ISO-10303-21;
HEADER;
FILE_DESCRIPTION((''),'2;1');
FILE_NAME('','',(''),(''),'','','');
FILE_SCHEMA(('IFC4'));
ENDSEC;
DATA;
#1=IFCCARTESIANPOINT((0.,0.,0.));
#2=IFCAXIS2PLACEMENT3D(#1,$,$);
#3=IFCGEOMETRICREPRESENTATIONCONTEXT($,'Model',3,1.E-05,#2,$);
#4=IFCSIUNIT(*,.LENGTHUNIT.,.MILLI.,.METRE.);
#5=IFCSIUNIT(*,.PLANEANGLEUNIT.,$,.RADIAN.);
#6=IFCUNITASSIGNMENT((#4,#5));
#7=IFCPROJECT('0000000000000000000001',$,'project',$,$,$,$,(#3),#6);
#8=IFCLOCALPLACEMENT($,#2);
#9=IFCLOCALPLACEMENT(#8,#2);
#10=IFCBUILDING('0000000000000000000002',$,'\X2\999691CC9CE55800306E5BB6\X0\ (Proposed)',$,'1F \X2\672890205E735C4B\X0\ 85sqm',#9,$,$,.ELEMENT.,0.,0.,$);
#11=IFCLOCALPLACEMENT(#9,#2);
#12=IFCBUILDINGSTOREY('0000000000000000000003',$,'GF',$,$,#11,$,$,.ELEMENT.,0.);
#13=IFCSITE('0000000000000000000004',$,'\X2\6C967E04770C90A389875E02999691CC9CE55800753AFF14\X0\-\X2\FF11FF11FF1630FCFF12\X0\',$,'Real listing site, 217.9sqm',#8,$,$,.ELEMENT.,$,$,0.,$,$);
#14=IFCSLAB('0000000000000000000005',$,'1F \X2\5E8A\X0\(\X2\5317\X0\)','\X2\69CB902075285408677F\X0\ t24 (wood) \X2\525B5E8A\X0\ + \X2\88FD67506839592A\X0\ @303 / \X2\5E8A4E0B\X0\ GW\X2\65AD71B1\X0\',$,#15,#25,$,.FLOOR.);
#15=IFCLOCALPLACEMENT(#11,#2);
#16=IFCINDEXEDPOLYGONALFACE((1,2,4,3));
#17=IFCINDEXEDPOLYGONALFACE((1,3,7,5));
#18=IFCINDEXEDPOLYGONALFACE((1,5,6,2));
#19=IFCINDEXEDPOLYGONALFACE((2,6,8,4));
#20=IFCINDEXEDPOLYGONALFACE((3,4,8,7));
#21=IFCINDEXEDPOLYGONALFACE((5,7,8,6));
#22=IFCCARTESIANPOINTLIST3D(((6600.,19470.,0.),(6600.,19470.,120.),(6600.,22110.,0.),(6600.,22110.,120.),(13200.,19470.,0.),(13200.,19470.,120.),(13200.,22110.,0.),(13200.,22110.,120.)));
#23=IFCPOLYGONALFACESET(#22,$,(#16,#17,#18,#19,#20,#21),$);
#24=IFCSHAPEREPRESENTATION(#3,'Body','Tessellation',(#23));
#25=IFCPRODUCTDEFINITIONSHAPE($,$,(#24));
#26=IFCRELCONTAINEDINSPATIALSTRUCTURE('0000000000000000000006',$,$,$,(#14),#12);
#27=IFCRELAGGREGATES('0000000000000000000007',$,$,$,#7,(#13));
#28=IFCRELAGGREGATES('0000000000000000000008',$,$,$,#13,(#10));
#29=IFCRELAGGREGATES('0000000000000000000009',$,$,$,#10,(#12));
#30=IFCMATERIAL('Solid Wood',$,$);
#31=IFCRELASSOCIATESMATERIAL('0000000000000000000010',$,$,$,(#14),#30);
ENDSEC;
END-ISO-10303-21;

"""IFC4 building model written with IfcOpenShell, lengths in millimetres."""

from ifc_helpers import new_model, si_unit, frame, frame_2d, origin, place, context, project, spatial, rectangle, extrude, material, element, save


model = new_model("IFC4")

# Units and contexts
model_context = context("Model", 3, precision=1e-05, world=origin())
ifc_project = project(units=[si_unit("LENGTHUNIT", "METRE", prefix="MILLI"), si_unit("PLANEANGLEUNIT", "RADIAN")], contexts=[model_context])

# Site, building, storey
site_placement = place(None, origin())
site = spatial("IfcSite", under=ifc_project, at=site_placement, Name="沖縄県那覇市首里鳥堀町４-１１６ー２", ObjectType="Real listing site, 217.9sqm", CompositionType="ELEMENT", RefElevation=0.0)
building_placement = place(site_placement, origin())
building = spatial("IfcBuilding", under=site, at=building_placement, Name="首里鳥堀の家 (Proposed)", ObjectType="1F 木造平屋 85sqm", CompositionType="ELEMENT", ElevationOfRefHeight=0.0, ElevationOfTerrain=0.0)
storey_placement = place(building_placement, origin())
storey = spatial("IfcBuildingStorey", under=building, at=storey_placement, Name="GF", CompositionType="ELEMENT", Elevation=0.0)

# Slab
ifc_material_1 = material(Name="Solid Wood")
slab_1_placement = place(storey_placement, frame((3300.0, 9735.0, 0.0)))
element("IfcSlab", 1, at=slab_1_placement, inside=storey, material=ifc_material_1, Name="1F 床(北)", Description="構造用合板 t24 (wood) 剛床 + 製材根太 @303 / 床下 GW断熱", PredefinedType="FLOOR", context=model_context, shape_type="SweptSolid", body=[
    extrude(rectangle(XDim=6600.0, YDim=2640.0, at=frame_2d((3300.0, 1320.0))), frame((3300.0, 9735.0, 0.0)), (0.0, 0.0, 1.0), 120.0),
])

save(model, "model.ifc")
